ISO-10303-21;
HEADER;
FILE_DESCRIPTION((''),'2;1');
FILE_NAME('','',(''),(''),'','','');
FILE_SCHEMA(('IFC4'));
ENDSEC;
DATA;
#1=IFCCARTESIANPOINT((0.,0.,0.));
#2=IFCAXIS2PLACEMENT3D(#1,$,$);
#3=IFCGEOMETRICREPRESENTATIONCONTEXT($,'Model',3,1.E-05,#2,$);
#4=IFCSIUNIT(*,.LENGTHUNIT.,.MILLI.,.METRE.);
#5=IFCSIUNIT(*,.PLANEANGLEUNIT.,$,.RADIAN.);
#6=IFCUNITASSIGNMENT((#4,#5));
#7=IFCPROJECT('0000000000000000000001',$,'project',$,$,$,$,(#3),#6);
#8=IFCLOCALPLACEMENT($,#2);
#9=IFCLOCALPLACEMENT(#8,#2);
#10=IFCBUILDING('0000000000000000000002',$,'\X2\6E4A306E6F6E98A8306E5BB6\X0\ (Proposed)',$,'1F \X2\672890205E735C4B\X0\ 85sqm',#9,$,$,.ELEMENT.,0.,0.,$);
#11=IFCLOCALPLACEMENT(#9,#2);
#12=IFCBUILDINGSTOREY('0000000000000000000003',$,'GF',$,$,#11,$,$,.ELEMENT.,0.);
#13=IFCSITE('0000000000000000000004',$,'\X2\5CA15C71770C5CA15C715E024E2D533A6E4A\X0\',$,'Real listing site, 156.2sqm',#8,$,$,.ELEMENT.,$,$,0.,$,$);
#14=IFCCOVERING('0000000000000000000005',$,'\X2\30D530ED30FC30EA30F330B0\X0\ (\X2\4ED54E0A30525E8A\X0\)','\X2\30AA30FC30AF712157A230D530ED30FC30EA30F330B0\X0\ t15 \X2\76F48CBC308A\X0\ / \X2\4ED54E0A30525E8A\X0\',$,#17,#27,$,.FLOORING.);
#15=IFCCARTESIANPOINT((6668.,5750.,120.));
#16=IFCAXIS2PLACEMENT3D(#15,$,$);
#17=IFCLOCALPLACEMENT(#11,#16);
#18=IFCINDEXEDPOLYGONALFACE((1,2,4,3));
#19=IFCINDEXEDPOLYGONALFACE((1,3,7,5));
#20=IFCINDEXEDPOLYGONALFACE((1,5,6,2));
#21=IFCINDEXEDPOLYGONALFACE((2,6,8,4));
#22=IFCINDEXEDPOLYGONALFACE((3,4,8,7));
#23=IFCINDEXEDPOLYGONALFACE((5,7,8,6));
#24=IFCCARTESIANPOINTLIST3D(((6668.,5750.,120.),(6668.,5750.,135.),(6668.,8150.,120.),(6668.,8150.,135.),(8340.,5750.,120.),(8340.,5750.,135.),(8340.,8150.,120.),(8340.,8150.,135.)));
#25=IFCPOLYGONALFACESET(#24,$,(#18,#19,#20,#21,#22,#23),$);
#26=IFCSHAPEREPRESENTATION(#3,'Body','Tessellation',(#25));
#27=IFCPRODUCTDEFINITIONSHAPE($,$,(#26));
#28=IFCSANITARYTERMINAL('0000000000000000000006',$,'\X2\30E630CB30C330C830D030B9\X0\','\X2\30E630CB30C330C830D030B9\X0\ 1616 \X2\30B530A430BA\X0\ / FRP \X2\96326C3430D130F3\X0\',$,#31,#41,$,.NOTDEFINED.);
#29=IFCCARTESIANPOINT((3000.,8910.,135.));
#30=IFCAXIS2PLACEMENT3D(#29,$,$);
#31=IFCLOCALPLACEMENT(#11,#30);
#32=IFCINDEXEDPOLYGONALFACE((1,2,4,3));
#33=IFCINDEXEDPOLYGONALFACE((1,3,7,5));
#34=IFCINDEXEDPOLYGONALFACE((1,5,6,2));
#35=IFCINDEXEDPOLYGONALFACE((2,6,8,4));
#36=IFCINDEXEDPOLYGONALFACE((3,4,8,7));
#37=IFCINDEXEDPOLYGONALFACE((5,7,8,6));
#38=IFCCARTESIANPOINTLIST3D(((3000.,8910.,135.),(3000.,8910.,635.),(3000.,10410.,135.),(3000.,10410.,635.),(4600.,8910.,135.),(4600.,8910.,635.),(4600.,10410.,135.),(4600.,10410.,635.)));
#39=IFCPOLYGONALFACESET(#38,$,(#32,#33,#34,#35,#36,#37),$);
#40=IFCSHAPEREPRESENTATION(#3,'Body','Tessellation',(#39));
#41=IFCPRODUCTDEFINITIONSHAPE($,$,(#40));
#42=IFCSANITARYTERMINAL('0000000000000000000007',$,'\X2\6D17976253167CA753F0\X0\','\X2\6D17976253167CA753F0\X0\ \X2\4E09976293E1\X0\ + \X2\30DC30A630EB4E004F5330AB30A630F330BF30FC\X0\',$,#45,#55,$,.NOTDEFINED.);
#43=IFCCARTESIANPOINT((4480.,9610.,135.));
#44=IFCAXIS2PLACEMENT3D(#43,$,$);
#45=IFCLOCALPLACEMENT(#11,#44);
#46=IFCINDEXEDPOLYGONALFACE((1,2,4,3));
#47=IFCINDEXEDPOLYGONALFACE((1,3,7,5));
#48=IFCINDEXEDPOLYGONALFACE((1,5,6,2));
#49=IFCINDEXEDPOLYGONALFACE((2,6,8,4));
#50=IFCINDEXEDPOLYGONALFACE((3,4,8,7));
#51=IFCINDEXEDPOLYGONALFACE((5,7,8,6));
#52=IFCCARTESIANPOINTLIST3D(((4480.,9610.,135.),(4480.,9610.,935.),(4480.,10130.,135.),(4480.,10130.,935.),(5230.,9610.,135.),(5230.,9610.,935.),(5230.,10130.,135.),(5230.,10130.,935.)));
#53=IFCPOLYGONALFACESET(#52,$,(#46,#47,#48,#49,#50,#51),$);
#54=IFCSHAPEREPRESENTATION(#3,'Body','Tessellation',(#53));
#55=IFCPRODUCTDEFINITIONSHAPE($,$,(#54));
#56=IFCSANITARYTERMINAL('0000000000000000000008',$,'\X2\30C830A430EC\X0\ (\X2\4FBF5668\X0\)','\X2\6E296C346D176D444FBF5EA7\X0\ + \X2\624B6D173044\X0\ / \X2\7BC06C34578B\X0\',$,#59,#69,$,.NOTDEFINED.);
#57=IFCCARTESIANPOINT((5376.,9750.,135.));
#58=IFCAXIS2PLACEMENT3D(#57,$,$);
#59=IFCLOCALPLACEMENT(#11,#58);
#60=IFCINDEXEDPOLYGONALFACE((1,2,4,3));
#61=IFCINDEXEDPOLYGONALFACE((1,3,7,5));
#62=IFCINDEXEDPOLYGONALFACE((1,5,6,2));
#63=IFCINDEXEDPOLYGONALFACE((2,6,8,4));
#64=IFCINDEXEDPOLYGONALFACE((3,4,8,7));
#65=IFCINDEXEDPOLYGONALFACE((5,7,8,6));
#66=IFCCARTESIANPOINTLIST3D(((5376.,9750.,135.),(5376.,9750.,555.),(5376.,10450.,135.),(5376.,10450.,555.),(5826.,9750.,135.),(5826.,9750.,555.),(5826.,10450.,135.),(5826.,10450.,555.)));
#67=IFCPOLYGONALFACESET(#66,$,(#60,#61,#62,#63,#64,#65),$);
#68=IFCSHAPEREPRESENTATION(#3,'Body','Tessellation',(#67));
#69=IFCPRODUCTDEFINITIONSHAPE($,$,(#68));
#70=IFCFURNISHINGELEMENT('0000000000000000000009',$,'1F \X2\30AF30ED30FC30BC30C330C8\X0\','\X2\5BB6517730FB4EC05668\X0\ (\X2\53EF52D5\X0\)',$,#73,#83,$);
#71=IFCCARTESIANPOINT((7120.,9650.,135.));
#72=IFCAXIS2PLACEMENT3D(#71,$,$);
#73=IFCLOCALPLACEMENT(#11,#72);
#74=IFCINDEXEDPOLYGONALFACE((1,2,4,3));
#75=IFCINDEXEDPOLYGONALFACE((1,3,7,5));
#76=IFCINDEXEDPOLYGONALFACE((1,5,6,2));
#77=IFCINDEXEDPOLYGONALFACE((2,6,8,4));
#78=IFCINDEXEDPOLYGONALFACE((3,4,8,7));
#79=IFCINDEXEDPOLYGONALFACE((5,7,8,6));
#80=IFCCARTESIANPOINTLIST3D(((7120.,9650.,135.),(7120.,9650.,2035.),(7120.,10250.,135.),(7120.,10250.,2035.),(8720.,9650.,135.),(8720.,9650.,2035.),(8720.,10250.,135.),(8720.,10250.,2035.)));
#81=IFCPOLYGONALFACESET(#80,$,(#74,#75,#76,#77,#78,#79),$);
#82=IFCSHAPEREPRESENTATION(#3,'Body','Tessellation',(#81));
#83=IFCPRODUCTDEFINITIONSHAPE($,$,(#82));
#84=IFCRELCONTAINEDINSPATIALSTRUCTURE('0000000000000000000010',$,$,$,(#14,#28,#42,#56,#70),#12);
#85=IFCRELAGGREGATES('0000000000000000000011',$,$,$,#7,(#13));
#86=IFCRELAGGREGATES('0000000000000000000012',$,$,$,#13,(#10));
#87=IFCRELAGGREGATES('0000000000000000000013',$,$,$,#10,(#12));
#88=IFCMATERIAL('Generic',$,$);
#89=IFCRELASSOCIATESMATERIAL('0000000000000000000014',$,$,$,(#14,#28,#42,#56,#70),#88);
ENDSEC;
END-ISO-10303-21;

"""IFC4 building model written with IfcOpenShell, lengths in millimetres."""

from ifc_helpers import new_model, si_unit, frame, frame_2d, origin, place, context, project, spatial, rectangle, extrude, material, element, save


model = new_model("IFC4")

# Units and contexts
model_context = context("Model", 3, precision=1e-05, world=origin())
ifc_project = project(units=[si_unit("LENGTHUNIT", "METRE", prefix="MILLI"), si_unit("PLANEANGLEUNIT", "RADIAN")], contexts=[model_context])

# Site, building, storey
site_placement = place(None, origin())
site = spatial("IfcSite", under=ifc_project, at=site_placement, Name="岡山県岡山市中区湊", ObjectType="Real listing site, 156.2sqm", CompositionType="ELEMENT", RefElevation=0.0)
building_placement = place(site_placement, origin())
building = spatial("IfcBuilding", under=site, at=building_placement, Name="湊の潮風の家 (Proposed)", ObjectType="1F 木造平屋 85sqm", CompositionType="ELEMENT", ElevationOfRefHeight=0.0, ElevationOfTerrain=0.0)
storey_placement = place(building_placement, origin())
storey = spatial("IfcBuildingStorey", under=building, at=storey_placement, Name="GF", CompositionType="ELEMENT", Elevation=0.0)

# Covering
ifc_material_1 = material(Name="Generic")
covering_1_placement = place(storey_placement, frame((6668.0, 5750.0, 120.0)))
element("IfcCovering", 1, at=covering_1_placement, inside=storey, material=ifc_material_1, Name="フローリング (仕上げ床)", Description="オーク無垢フローリング t15 直貼り / 仕上げ床", PredefinedType="FLOORING", context=model_context, shape_type="SweptSolid", body=[
    extrude(rectangle(XDim=1672.0, YDim=2400.0, at=frame_2d((836.0, 1200.0))), frame((6668.0, 5750.0, 120.0)), (0.0, 0.0, 1.0), 15.0),
])

# Sanitary terminals
sanitary_terminal_1_placement = place(storey_placement, frame((3000.0, 8910.0, 135.0)))
element("IfcSanitaryTerminal", 2, at=sanitary_terminal_1_placement, inside=storey, material=ifc_material_1, Name="ユニットバス", Description="ユニットバス 1616 サイズ / FRP 防水パン", PredefinedType="NOTDEFINED", context=model_context, shape_type="SweptSolid", body=[
    extrude(rectangle(XDim=1600.0, YDim=1500.0, at=frame_2d((800.0, 750.0))), frame((3000.0, 8910.0, 135.0)), (0.0, 0.0, 1.0), 500.0),
])
sanitary_terminal_2_placement = place(storey_placement, frame((4480.0, 9610.0, 135.0)))
element("IfcSanitaryTerminal", 3, at=sanitary_terminal_2_placement, inside=storey, material=ifc_material_1, Name="洗面化粧台", Description="洗面化粧台 三面鏡 + ボウル一体カウンター", PredefinedType="NOTDEFINED", context=model_context, shape_type="SweptSolid", body=[
    extrude(rectangle(XDim=750.0, YDim=520.0, at=frame_2d((375.0, 260.0))), frame((4480.0, 9610.0, 135.0)), (0.0, 0.0, 1.0), 800.0),
])
sanitary_terminal_3_placement = place(storey_placement, frame((5376.0, 9750.0, 135.0)))
element("IfcSanitaryTerminal", 4, at=sanitary_terminal_3_placement, inside=storey, material=ifc_material_1, Name="トイレ (便器)", Description="温水洗浄便座 + 手洗い / 節水型", PredefinedType="NOTDEFINED", context=model_context, shape_type="SweptSolid", body=[
    extrude(rectangle(XDim=450.0, YDim=700.0, at=frame_2d((225.0, 350.0))), frame((5376.0, 9750.0, 135.0)), (0.0, 0.0, 1.0), 420.0),
])

# Furnishing element
furnishing_placement = place(storey_placement, frame((7120.0, 9650.0, 135.0)))
element("IfcFurnishingElement", 5, at=furnishing_placement, inside=storey, material=ifc_material_1, Name="1F クローゼット", Description="家具・什器 (可動)", context=model_context, shape_type="SweptSolid", body=[
    extrude(rectangle(XDim=1600.0, YDim=600.0, at=frame_2d((800.0, 300.0))), frame((7120.0, 9650.0, 135.0)), (0.0, 0.0, 1.0), 1900.0),
])

save(model, "model.ifc")
